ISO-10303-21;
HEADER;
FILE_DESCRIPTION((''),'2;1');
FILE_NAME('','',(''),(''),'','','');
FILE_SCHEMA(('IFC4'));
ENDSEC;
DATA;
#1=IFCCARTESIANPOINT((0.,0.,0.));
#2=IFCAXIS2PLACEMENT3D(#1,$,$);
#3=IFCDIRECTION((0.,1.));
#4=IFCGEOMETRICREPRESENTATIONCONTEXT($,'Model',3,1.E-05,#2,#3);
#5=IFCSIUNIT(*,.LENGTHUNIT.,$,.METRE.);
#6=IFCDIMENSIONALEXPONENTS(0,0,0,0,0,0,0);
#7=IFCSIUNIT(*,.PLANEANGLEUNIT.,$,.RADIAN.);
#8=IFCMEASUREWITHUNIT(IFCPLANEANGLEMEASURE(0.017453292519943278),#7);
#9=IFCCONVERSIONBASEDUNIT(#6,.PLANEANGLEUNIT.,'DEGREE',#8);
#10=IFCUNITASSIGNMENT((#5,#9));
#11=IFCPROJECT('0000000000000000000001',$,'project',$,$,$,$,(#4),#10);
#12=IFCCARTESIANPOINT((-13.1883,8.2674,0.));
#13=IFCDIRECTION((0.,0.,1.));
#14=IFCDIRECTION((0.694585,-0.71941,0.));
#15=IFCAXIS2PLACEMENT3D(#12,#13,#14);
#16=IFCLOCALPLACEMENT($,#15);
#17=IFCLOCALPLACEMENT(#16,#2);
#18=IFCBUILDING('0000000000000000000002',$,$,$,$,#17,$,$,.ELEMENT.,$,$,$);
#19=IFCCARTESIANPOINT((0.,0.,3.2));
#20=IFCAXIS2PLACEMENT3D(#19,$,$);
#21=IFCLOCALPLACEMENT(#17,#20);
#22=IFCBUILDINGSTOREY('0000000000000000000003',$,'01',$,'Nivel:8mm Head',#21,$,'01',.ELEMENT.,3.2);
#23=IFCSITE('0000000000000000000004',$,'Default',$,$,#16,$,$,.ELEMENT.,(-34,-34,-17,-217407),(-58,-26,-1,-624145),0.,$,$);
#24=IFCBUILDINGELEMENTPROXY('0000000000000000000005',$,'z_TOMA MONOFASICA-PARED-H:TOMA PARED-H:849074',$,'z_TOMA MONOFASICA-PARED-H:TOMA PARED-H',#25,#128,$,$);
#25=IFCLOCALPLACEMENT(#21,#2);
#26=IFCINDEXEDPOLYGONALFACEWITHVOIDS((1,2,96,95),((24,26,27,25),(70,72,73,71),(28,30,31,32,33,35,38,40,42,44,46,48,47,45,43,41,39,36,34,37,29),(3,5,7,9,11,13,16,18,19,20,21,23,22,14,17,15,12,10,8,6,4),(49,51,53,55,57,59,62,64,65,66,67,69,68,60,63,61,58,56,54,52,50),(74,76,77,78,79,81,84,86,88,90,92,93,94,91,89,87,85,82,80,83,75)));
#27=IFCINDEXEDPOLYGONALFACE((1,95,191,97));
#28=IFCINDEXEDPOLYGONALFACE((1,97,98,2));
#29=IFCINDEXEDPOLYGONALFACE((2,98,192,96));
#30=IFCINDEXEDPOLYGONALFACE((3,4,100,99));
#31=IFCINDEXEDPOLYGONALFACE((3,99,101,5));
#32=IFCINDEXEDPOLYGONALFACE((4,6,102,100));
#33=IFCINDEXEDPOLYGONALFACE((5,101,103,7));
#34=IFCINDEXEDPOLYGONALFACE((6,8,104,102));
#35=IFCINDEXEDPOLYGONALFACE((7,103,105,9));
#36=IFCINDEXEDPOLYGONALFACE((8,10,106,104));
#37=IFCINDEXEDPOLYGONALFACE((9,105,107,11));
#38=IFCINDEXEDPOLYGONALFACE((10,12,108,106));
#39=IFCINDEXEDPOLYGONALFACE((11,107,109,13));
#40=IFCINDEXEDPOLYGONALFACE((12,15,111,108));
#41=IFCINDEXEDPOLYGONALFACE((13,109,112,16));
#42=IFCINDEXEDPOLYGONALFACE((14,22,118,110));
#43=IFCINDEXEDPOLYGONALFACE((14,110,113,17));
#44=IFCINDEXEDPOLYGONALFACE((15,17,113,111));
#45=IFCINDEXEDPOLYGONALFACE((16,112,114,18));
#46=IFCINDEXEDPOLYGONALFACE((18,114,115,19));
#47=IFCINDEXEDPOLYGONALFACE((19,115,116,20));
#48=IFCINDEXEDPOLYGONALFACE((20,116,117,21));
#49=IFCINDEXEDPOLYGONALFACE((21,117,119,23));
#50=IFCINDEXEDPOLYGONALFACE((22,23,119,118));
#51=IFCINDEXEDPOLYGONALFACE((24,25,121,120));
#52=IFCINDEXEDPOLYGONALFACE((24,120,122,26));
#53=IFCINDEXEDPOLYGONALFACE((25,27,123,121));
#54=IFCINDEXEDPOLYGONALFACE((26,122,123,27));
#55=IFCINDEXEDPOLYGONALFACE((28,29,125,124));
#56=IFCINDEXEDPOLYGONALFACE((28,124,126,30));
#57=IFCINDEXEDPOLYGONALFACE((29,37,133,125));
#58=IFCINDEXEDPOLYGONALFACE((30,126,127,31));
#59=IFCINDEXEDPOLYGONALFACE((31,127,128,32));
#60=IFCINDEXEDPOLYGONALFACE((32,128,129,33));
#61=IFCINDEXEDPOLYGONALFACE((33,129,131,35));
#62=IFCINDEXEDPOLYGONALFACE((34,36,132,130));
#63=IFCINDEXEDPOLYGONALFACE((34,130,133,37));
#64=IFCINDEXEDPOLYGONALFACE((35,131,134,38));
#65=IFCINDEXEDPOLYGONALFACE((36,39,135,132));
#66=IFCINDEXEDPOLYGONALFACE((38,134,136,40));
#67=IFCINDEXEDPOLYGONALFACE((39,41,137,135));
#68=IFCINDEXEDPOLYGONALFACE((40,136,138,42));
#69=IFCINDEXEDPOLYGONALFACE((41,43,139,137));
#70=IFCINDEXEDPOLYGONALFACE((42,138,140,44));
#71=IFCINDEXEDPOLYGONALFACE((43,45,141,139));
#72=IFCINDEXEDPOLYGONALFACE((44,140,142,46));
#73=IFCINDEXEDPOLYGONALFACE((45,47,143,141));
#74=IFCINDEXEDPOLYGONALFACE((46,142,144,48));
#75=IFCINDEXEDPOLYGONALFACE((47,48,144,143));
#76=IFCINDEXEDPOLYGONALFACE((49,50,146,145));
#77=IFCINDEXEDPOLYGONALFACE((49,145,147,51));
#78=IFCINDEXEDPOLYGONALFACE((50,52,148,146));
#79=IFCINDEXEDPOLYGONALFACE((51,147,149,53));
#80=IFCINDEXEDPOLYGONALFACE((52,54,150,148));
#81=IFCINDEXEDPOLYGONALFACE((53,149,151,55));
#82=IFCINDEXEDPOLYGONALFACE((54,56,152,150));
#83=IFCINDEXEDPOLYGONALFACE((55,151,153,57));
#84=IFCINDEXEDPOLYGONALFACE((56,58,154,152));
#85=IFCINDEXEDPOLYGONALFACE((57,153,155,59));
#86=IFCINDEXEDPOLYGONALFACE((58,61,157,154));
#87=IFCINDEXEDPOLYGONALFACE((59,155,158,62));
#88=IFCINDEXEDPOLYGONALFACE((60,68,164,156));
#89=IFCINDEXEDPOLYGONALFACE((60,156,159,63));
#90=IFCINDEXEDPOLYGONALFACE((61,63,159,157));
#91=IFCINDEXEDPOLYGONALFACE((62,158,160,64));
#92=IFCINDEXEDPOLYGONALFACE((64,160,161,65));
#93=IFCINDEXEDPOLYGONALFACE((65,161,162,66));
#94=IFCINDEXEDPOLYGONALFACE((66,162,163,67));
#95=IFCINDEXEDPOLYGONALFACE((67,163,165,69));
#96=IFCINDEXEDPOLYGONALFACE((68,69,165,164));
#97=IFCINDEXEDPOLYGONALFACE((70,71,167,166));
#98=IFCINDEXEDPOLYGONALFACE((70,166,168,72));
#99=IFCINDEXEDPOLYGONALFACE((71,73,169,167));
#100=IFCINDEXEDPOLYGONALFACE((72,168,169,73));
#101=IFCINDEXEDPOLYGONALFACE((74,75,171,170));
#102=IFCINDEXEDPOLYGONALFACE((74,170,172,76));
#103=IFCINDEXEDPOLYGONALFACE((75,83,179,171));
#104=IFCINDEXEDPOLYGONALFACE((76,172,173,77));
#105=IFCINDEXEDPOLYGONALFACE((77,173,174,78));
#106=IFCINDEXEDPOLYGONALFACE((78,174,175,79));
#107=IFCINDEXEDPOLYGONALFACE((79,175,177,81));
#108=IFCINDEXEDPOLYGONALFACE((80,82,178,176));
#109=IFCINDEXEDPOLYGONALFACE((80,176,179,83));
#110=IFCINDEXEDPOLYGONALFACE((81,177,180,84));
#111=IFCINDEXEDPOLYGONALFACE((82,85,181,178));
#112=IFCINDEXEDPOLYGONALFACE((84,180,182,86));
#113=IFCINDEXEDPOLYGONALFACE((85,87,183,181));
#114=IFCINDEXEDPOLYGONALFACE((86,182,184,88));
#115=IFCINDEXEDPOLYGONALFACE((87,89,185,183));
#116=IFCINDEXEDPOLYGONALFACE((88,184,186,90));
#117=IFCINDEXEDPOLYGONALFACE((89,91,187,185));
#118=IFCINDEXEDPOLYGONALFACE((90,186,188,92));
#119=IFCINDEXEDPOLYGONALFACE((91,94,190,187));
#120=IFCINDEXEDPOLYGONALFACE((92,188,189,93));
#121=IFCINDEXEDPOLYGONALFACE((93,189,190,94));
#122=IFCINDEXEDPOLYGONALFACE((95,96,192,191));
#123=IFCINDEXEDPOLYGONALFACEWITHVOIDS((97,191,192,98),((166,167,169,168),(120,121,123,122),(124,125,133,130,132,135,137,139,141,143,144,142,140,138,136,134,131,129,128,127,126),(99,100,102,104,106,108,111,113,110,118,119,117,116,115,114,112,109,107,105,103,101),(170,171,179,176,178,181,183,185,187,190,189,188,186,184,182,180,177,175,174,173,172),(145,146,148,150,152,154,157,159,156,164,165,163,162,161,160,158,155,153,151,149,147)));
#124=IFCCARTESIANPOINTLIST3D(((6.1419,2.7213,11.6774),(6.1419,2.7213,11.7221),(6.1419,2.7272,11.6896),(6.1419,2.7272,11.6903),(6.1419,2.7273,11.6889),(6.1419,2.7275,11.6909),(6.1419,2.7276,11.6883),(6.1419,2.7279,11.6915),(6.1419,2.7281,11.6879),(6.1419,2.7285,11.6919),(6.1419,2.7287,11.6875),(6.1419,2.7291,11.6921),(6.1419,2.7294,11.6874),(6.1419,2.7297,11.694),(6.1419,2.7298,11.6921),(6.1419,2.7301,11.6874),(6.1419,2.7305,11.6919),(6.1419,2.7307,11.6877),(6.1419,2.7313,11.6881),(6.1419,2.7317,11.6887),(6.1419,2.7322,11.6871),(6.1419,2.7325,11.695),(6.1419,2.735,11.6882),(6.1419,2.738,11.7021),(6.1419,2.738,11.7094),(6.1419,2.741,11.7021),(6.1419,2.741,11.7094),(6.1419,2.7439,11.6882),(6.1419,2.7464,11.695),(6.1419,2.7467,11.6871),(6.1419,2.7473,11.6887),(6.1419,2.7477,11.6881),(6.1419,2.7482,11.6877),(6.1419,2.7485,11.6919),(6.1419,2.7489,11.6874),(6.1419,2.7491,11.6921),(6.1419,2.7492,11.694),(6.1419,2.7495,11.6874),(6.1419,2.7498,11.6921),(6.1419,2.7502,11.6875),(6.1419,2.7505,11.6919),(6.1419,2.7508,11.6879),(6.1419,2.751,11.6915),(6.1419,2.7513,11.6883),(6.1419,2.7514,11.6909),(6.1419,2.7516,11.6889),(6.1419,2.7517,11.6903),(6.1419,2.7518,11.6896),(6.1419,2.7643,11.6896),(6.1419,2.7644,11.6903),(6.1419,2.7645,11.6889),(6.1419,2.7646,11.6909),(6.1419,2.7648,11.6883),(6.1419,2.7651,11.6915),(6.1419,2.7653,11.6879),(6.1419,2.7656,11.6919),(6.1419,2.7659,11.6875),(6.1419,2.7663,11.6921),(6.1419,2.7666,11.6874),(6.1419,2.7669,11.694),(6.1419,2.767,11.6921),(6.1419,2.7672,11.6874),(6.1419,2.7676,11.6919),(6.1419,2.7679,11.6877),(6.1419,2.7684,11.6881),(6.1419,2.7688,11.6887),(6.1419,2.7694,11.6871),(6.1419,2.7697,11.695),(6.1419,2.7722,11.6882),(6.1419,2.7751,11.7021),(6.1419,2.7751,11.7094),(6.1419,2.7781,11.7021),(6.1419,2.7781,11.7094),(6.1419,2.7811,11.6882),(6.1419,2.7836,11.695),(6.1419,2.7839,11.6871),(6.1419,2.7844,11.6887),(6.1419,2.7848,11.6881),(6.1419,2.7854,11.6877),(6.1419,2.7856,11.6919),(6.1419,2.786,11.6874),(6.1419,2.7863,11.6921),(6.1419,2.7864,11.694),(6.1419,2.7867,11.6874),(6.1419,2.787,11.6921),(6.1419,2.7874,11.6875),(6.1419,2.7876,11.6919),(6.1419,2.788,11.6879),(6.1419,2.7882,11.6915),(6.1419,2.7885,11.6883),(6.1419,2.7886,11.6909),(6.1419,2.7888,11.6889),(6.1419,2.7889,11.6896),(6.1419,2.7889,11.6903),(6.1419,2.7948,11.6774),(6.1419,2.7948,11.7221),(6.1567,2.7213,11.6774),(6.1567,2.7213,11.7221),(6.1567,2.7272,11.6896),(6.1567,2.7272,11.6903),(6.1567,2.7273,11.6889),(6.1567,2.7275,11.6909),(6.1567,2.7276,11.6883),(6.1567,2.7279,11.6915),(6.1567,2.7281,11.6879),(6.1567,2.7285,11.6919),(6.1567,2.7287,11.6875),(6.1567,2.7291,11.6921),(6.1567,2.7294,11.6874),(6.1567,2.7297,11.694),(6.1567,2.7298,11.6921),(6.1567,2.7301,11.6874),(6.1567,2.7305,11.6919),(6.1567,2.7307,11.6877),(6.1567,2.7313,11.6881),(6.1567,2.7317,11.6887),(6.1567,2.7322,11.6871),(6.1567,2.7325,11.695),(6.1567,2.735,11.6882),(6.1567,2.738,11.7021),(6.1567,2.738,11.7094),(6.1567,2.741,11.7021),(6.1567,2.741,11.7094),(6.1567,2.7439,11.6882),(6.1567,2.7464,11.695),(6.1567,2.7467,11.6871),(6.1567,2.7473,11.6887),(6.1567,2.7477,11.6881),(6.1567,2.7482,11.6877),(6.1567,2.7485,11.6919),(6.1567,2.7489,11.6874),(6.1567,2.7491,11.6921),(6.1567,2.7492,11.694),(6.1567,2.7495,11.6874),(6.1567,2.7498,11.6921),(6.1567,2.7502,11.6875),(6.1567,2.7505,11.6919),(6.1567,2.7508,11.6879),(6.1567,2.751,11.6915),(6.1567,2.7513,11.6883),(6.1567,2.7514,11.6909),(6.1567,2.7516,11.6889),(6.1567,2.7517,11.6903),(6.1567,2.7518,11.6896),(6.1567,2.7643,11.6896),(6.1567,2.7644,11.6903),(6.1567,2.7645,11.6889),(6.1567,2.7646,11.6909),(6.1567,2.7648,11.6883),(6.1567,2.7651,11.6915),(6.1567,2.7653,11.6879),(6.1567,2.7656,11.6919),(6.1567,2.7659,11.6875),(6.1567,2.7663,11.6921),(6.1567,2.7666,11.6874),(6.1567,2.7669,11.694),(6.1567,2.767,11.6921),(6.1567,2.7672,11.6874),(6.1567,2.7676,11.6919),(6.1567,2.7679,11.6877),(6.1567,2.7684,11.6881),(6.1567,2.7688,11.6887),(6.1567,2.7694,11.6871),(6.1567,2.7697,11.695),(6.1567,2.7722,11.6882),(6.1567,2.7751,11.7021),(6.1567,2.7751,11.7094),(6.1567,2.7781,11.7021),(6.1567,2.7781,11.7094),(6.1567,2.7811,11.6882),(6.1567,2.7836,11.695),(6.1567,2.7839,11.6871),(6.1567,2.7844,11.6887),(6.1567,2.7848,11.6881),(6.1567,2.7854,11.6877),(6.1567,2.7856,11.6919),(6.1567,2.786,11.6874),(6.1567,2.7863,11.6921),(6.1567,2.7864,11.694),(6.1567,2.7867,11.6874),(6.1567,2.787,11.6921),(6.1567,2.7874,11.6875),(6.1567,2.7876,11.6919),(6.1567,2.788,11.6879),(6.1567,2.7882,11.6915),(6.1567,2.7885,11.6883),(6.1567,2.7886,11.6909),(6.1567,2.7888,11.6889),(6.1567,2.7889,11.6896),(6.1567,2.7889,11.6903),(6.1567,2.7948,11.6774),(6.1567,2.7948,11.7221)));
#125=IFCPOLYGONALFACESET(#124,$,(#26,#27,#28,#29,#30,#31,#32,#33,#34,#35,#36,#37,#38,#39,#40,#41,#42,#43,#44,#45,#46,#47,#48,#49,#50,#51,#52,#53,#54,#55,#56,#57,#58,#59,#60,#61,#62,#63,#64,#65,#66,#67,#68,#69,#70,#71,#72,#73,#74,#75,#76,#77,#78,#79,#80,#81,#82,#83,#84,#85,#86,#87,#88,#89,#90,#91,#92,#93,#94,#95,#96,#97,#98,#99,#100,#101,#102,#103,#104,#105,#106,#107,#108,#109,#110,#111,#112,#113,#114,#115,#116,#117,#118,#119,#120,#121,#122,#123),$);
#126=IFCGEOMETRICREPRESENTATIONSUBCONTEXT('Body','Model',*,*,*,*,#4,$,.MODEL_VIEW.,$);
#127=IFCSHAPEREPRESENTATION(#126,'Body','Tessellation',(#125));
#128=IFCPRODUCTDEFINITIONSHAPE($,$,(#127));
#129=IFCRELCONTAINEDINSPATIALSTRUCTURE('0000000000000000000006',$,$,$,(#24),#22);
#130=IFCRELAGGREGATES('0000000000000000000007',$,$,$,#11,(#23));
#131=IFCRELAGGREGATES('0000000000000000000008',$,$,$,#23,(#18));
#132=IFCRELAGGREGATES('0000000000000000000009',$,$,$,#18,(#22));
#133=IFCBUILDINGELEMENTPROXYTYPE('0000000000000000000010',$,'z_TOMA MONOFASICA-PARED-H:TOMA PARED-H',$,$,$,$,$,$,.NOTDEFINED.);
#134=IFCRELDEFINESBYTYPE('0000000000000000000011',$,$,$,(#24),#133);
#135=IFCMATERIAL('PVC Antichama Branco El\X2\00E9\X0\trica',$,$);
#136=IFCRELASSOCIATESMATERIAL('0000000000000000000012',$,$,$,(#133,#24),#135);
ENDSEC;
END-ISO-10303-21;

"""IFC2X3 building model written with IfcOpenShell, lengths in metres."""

from ifc_helpers import new_model, entity, si_unit, converted_unit, direction, frame, frame_2d, origin, place, context, subcontext, project, spatial, polyline, circle_curve, parameter, trimmed, segment, composite_curve, outline, extrude, source, transform, mapped, material, type_object, type_shapes, element, save


model = new_model("IFC2X3")

# Units and contexts
model_context = context("Model", 3, precision=1e-05, world=origin(), true_north=direction((0.0, 1.0)))
body_context = subcontext(model_context, "Body", "Model", "MODEL_VIEW")
ifc_project = project(units=[si_unit("LENGTHUNIT", "METRE"), converted_unit("PLANEANGLEUNIT", "DEGREE", entity("IfcPlaneAngleMeasure", 0.017453292519943278), si_unit("PLANEANGLEUNIT", "RADIAN"), dimensions=[0, 0, 0, 0, 0, 0, 0])], contexts=[model_context])

# Site, building, storey
site_placement = place(None, frame((-13.1883, 8.2674, 0.0), z_axis=(0.0, 0.0, 1.0), x_axis=(0.694585, -0.71941, 0.0)))
site = spatial("IfcSite", under=ifc_project, at=site_placement, Name="Default", CompositionType="ELEMENT", RefLatitude=(-34, -34, -17, -217407), RefLongitude=(-58, -26, -1, -624145), RefElevation=0.0)
building_placement = place(site_placement, origin())
building = spatial("IfcBuilding", under=site, at=building_placement, CompositionType="ELEMENT")
storey_placement = place(building_placement, frame((0.0, 0.0, 3.2)))
storey = spatial("IfcBuildingStorey", under=building, at=storey_placement, Name="01", ObjectType="Nivel:8mm Head", LongName="01", CompositionType="ELEMENT", Elevation=3.2)

# Building element proxy
ifc_material_1 = material(Name="PVC Antichama Branco Elétrica")
building_element_proxy_type_1 = type_object("IfcBuildingElementProxyType", Name="z_TOMA MONOFASICA-PARED-H:TOMA PARED-H", PredefinedType="NOTDEFINED", material=ifc_material_1)
shared_shape_1 = source(origin(), body_context, "Body", "SweptSolid", [
    extrude(outline(polyline([(-0.0368, -0.0223), (0.0368, -0.0223), (0.0368, 0.0223), (-0.0368, 0.0223), (-0.0368, -0.0223)]), holes=[composite_curve([segment(polyline([(0.0141, 0.0115), (0.0116, 0.0047)]), True, "CONTINUOUS"), segment(polyline([(0.0116, 0.0047), (0.0088, 0.0057)]), True, "CONTINUOUS"), segment(polyline([(0.0088, 0.0057), (0.0096, 0.0078)]), True, "CONTINUOUS"), segment(trimmed(circle_curve(frame_2d((0.0087, 0.0099), x_axis=(1.0, 0.0)), 0.0024), [parameter(27.118901)], [parameter(292.881099)], True, "PARAMETER"), False, "CONTINUOUS"), segment(polyline([(0.0108, 0.011), (0.0113, 0.0126)]), True, "CONTINUOUS"), segment(polyline([(0.0113, 0.0126), (0.0141, 0.0115)]), True, "CONTINUOUS")], self_intersect=False), composite_curve([segment(polyline([(0.0255, 0.0047), (0.023, 0.0115)]), True, "CONTINUOUS"), segment(polyline([(0.023, 0.0115), (0.0258, 0.0126)]), True, "CONTINUOUS"), segment(polyline([(0.0258, 0.0126), (0.0264, 0.011)]), True, "CONTINUOUS"), segment(trimmed(circle_curve(frame_2d((0.0285, 0.0099), x_axis=(1.0, 0.0)), 0.0024), [parameter(247.118901)], [parameter(152.881099)], True, "PARAMETER"), False, "CONTINUOUS"), segment(polyline([(0.0276, 0.0078), (0.0283, 0.0057)]), True, "CONTINUOUS"), segment(polyline([(0.0283, 0.0057), (0.0255, 0.0047)]), True, "CONTINUOUS")], self_intersect=False), polyline([(0.0201, -0.0024), (0.0201, -0.0097), (0.0171, -0.0097), (0.0171, -0.0024), (0.0201, -0.0024)]), composite_curve([segment(polyline([(-0.0141, 0.0115), (-0.0113, 0.0126)]), True, "CONTINUOUS"), segment(polyline([(-0.0113, 0.0126), (-0.0108, 0.011)]), True, "CONTINUOUS"), segment(trimmed(circle_curve(frame_2d((-0.0087, 0.0099), x_axis=(1.0, 0.0)), 0.0024), [parameter(247.118901)], [parameter(152.881099)], True, "PARAMETER"), False, "CONTINUOUS"), segment(polyline([(-0.0096, 0.0078), (-0.0088, 0.0057)]), True, "CONTINUOUS"), segment(polyline([(-0.0088, 0.0057), (-0.0116, 0.0047)]), True, "CONTINUOUS"), segment(polyline([(-0.0116, 0.0047), (-0.0141, 0.0115)]), True, "CONTINUOUS")], self_intersect=False), composite_curve([segment(polyline([(-0.0255, 0.0047), (-0.0283, 0.0057)]), True, "CONTINUOUS"), segment(polyline([(-0.0283, 0.0057), (-0.0276, 0.0078)]), True, "CONTINUOUS"), segment(trimmed(circle_curve(frame_2d((-0.0285, 0.0099), x_axis=(1.0, 0.0)), 0.0024), [parameter(27.118901)], [parameter(292.881099)], True, "PARAMETER"), False, "CONTINUOUS"), segment(polyline([(-0.0264, 0.011), (-0.0258, 0.0126)]), True, "CONTINUOUS"), segment(polyline([(-0.0258, 0.0126), (-0.023, 0.0115)]), True, "CONTINUOUS"), segment(polyline([(-0.023, 0.0115), (-0.0255, 0.0047)]), True, "CONTINUOUS")], self_intersect=False), polyline([(-0.0201, -0.0024), (-0.0171, -0.0024), (-0.0171, -0.0097), (-0.0201, -0.0097), (-0.0201, -0.0024)])]), frame((0.0, -0.005, 0.0223), z_axis=(0.0, 1.0, 0.0), x_axis=(1.0, 0.0, 0.0)), (0.0, 0.0, 1.0), 0.0148),
])
type_shapes(building_element_proxy_type_1, [shared_shape_1])
for number, where, z_axis, x_axis, name in (
    (1, (6.1469, 2.758, 11.6774), (0.0, 0.0, 1.0), (0.0, -1.0, 0.0), "z_TOMA MONOFASICA-PARED-H:TOMA PARED-H:849074"),
):
    element("IfcBuildingElementProxy", number, at=place(storey_placement, frame(where, z_axis=z_axis, x_axis=x_axis)), inside=storey, type_object=building_element_proxy_type_1, material=ifc_material_1, Name=name, ObjectType="z_TOMA MONOFASICA-PARED-H:TOMA PARED-H", context=body_context, shape_type="MappedRepresentation", body=[
        mapped(shared_shape_1, transform((0.0, 0.0, 0.0), scale=1.0)),
    ])

save(model, "model.ifc")
